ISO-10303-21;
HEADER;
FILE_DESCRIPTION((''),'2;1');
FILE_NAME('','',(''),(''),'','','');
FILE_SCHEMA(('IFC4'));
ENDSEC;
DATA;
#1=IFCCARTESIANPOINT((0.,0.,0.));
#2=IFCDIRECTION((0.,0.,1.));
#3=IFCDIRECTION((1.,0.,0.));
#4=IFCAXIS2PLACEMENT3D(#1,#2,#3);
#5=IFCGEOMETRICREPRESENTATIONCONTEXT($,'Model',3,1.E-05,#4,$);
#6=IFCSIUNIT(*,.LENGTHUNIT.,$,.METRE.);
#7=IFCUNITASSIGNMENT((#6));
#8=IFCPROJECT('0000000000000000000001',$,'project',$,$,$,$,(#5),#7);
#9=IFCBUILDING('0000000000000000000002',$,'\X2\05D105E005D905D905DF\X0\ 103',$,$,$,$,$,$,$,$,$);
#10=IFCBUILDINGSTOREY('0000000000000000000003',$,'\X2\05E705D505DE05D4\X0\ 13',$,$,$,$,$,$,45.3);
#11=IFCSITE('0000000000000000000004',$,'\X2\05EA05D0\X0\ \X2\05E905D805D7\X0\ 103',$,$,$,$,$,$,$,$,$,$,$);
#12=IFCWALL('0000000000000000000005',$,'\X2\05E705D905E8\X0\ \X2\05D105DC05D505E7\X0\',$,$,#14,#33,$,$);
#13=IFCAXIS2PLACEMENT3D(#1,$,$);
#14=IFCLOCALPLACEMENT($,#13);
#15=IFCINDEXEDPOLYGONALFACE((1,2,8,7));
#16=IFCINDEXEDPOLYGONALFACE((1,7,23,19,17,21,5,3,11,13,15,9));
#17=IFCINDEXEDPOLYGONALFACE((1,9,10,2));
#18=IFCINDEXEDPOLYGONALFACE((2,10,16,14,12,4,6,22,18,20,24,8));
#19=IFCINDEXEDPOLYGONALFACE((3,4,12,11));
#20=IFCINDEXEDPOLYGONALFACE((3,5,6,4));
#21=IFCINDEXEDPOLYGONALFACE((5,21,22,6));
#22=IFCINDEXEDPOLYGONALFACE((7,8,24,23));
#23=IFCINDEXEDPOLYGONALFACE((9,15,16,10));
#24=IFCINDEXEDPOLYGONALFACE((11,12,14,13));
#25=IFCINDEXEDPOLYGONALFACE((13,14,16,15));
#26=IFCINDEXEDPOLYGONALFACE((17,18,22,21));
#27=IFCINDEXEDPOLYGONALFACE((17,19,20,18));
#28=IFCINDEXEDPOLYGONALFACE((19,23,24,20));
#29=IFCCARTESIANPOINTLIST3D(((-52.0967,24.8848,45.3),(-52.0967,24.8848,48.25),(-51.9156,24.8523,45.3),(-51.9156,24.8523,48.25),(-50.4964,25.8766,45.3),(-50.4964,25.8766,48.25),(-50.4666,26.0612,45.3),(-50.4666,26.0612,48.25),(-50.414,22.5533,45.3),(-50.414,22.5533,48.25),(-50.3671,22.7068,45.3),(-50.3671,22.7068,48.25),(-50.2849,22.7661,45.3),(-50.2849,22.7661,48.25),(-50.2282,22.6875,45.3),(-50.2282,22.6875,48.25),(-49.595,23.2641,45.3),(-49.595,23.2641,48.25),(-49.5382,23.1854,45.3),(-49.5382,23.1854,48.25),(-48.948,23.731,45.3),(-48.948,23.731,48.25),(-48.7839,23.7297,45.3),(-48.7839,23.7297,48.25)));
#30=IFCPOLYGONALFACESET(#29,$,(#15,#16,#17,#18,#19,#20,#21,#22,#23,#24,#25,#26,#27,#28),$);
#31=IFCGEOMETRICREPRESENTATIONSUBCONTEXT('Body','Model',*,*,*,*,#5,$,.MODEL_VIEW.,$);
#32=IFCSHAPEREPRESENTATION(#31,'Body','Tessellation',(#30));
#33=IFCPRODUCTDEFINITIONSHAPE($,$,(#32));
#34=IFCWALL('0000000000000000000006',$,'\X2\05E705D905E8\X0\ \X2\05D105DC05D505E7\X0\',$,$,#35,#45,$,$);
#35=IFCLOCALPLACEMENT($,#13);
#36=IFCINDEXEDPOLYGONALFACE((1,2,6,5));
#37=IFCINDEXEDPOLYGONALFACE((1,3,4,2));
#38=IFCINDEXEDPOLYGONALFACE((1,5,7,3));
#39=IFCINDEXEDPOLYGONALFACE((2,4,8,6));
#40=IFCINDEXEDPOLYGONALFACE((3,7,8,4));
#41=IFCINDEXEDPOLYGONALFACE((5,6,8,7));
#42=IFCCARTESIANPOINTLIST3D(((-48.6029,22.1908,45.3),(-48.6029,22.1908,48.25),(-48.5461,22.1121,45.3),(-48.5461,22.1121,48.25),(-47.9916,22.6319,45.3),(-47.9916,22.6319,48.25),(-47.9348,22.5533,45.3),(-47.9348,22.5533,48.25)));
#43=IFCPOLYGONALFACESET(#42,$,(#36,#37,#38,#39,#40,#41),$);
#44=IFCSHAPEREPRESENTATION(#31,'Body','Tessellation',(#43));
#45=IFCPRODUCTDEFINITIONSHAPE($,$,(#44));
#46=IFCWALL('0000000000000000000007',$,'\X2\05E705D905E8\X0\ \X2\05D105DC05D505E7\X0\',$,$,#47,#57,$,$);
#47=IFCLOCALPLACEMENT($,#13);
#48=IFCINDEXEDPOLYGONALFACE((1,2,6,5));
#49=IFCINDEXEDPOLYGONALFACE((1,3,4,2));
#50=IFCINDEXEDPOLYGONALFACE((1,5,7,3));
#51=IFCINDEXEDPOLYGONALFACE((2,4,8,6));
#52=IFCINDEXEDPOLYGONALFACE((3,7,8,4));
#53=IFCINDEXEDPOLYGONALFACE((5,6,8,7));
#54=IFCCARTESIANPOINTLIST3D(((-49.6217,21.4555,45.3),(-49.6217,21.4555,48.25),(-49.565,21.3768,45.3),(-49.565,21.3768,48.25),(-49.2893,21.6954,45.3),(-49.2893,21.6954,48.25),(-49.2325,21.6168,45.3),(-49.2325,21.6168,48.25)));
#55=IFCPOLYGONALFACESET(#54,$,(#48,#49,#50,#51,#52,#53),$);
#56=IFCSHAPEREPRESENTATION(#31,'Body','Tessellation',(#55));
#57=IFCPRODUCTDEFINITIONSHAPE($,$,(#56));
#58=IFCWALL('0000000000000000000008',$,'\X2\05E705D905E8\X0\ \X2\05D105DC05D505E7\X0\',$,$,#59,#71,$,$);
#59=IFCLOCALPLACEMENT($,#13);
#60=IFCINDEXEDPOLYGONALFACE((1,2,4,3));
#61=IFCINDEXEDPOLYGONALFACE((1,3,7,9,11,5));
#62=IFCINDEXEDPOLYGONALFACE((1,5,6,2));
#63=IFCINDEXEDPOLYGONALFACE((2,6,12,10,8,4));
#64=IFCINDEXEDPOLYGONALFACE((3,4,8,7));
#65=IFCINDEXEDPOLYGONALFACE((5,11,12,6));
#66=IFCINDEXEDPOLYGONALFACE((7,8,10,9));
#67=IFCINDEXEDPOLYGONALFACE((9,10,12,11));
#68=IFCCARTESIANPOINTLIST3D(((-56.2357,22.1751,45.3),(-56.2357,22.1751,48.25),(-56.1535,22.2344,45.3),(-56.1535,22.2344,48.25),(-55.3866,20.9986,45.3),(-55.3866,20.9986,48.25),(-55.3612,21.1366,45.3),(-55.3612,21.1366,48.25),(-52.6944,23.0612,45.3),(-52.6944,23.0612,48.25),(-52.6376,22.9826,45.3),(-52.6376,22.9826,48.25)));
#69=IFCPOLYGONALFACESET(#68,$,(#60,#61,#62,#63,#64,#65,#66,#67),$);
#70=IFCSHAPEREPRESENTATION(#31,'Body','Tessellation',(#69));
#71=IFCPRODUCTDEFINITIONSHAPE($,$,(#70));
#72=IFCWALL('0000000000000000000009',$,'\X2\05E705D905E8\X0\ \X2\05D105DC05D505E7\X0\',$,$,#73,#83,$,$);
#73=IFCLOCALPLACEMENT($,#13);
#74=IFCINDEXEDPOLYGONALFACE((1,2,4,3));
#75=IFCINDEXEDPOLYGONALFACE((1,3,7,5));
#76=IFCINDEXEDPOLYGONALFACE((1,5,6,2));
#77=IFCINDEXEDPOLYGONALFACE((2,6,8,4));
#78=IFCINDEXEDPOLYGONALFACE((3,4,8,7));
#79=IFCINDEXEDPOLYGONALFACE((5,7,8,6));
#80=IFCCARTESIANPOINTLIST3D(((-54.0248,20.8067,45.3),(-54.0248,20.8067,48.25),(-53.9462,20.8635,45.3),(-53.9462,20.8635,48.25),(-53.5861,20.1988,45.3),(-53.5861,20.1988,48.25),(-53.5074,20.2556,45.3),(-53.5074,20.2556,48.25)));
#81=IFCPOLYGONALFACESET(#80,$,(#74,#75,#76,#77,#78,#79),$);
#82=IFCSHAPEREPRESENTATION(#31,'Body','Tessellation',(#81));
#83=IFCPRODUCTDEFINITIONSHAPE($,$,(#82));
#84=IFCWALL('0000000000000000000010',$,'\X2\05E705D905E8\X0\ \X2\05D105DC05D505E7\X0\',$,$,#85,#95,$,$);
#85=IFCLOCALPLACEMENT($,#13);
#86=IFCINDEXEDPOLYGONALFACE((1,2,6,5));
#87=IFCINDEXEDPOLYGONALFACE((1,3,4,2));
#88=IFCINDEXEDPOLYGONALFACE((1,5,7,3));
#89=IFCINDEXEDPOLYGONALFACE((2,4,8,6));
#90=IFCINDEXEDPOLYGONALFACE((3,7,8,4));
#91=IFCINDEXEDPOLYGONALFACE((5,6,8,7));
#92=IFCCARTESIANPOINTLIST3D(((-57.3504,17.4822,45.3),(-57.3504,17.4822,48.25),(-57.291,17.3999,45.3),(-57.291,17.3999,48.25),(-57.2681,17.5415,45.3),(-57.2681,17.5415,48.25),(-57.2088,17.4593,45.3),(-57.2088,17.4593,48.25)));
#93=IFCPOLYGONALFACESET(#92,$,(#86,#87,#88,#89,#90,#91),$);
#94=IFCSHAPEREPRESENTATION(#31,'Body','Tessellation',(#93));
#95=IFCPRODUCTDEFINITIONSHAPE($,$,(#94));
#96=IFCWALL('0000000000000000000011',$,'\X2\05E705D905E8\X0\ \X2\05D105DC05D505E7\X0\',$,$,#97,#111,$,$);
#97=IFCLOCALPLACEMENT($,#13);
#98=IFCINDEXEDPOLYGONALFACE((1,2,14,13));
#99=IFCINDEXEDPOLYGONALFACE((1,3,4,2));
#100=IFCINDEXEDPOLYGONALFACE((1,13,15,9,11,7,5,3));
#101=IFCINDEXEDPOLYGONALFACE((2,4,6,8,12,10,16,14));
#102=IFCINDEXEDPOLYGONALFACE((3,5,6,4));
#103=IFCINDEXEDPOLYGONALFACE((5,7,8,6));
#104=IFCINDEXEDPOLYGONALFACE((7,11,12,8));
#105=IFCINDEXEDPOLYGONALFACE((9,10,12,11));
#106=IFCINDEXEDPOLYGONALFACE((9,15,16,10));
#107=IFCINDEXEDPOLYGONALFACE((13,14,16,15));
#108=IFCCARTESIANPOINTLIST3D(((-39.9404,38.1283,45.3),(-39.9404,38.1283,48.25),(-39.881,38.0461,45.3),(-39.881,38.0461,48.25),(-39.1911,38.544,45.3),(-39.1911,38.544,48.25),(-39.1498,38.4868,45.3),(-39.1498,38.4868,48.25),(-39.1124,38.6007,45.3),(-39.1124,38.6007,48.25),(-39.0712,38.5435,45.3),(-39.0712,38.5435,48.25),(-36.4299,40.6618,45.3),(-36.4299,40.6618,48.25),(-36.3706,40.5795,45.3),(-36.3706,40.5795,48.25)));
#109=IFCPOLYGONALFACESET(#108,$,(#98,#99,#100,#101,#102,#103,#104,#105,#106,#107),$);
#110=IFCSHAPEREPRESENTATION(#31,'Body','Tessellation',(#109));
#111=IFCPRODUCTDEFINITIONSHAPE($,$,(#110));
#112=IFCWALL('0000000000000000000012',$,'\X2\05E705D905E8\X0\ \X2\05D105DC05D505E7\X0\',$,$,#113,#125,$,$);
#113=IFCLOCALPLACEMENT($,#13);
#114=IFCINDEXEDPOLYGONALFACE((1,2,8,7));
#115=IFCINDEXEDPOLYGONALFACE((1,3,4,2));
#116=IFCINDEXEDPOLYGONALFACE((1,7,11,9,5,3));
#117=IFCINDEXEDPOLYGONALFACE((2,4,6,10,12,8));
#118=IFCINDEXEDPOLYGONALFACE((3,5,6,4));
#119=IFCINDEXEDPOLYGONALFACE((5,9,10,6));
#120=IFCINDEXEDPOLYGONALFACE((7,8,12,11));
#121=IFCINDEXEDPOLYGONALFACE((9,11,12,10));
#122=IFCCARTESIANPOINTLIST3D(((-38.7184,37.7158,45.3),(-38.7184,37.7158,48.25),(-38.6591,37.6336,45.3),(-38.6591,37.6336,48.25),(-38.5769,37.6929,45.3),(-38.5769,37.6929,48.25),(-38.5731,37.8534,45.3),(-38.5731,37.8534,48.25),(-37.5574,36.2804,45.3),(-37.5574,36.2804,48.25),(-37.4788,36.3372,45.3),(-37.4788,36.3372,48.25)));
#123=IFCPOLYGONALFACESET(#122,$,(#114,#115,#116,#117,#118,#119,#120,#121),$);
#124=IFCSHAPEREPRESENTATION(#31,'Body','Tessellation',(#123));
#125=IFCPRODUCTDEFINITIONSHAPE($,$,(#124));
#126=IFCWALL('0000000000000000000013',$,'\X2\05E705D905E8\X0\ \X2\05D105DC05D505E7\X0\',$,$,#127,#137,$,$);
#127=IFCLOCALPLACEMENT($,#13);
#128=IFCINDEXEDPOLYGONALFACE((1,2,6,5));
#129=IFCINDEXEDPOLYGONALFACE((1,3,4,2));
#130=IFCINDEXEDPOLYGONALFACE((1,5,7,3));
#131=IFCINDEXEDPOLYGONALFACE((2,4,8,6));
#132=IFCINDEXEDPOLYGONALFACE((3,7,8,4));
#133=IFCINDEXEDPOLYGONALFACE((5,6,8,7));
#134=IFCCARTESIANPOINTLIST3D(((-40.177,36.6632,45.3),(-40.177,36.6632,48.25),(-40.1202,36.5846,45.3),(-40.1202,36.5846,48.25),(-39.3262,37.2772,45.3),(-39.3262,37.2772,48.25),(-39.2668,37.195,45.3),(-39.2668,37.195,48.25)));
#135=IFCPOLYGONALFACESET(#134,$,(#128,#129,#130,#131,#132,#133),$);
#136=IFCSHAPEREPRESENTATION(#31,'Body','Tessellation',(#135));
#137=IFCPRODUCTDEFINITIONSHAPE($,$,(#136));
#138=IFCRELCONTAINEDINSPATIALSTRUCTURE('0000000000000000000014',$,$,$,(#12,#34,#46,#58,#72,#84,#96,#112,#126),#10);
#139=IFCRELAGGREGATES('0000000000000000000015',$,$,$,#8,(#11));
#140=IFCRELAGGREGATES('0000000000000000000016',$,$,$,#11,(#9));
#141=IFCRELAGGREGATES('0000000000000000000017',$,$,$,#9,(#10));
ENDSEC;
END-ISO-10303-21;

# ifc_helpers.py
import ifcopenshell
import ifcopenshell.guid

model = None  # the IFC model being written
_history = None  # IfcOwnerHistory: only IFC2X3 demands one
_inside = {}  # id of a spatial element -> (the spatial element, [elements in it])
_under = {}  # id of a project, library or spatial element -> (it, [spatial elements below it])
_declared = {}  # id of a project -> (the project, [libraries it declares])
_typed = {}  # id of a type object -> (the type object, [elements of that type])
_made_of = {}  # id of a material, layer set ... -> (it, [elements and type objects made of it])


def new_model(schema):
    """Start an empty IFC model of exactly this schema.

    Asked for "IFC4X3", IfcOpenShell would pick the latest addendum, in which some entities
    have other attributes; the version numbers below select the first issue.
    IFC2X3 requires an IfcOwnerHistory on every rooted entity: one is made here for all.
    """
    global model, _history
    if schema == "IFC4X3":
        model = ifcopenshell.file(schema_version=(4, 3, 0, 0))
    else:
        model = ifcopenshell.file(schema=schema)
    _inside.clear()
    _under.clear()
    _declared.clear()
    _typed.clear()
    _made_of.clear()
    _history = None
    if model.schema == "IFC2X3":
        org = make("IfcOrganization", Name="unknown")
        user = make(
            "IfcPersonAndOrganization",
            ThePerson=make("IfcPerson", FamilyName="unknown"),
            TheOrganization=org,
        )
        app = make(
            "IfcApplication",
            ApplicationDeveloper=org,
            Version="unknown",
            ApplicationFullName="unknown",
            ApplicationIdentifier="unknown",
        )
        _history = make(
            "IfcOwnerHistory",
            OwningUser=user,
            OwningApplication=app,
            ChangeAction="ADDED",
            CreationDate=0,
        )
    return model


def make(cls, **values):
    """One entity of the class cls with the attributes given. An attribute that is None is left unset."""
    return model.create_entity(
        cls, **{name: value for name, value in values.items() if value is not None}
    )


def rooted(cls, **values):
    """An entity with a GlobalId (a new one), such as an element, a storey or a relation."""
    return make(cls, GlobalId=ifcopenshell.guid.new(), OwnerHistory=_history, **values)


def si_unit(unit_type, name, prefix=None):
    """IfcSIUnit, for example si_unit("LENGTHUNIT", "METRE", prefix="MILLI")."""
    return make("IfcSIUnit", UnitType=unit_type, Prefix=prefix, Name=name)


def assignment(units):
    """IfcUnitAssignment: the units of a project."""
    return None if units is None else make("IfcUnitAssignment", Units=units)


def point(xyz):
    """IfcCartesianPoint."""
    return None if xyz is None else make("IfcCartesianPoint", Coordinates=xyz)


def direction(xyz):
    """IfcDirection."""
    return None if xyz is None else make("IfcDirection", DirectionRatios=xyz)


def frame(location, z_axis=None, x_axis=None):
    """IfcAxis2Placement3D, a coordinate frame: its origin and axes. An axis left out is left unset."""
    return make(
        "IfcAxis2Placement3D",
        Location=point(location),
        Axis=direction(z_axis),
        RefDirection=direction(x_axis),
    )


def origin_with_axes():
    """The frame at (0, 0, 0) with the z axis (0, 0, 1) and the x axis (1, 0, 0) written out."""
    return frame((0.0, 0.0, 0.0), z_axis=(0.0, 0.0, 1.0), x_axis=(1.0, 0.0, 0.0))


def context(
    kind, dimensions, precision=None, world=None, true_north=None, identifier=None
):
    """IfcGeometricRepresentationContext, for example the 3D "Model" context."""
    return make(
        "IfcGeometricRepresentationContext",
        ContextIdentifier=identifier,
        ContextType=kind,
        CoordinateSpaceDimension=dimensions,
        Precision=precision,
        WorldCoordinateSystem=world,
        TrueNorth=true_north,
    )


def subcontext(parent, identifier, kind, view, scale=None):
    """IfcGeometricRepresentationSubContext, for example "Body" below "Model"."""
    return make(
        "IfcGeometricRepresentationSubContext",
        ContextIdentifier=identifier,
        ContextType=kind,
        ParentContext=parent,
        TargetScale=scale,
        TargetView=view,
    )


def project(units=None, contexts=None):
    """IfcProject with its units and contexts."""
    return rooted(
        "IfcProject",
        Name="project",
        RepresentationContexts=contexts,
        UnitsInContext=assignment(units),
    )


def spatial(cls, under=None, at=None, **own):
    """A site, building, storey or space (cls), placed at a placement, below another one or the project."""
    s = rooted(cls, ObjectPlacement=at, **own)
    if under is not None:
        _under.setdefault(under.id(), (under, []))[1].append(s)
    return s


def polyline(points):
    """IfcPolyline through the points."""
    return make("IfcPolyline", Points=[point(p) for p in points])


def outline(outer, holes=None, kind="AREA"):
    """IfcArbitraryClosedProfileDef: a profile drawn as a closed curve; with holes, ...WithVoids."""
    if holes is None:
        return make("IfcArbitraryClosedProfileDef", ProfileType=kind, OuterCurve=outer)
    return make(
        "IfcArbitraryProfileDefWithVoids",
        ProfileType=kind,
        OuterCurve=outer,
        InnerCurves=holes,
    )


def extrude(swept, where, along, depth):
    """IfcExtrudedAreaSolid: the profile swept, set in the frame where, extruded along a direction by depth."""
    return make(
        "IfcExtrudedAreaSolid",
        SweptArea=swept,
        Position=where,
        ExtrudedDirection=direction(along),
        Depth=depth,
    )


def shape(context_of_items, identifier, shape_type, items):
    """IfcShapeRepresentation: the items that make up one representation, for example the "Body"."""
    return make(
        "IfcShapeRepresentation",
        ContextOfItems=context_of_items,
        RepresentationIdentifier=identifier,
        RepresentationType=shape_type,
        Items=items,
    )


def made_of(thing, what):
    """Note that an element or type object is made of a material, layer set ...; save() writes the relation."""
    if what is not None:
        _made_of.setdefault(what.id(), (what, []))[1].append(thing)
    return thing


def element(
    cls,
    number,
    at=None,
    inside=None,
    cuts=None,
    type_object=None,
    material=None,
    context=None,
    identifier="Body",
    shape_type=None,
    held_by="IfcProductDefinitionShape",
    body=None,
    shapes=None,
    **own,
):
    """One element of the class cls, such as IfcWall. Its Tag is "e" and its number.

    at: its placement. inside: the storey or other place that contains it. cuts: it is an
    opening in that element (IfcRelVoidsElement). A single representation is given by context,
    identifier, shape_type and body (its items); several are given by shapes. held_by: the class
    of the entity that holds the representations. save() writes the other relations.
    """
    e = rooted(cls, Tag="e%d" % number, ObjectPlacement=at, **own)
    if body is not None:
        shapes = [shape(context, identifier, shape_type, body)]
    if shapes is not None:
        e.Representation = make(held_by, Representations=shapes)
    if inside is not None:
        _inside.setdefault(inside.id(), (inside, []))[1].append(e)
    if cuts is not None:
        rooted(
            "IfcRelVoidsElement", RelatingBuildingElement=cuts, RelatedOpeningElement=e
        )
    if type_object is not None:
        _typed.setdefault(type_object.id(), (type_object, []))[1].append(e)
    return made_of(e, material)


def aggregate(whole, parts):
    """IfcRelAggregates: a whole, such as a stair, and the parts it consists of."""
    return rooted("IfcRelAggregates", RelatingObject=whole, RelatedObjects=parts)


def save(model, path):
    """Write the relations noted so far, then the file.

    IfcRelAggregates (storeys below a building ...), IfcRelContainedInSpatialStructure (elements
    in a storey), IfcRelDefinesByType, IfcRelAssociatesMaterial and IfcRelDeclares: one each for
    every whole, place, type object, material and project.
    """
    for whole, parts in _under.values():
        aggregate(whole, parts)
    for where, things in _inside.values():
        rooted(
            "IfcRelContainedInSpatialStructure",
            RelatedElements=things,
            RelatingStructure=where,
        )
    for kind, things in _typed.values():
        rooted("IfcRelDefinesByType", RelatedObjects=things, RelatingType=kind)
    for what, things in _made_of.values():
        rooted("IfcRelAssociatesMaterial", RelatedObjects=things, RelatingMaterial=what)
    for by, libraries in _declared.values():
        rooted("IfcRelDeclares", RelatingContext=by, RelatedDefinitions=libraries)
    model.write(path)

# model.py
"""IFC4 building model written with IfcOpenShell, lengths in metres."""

from ifc_helpers import new_model, si_unit, frame, origin_with_axes, context, subcontext, project, spatial, polyline, outline, extrude, element, save


model = new_model("IFC4")

# Units and contexts
model_context = context("Model", 3, precision=1e-05, world=origin_with_axes())
body_context = subcontext(model_context, "Body", "Model", "MODEL_VIEW")
ifc_project = project(units=[si_unit("LENGTHUNIT", "METRE")], contexts=[model_context])

# Site, building, storey
site = spatial("IfcSite", under=ifc_project, Name="תא שטח 103")
building = spatial("IfcBuilding", under=site, Name="בניין 103")
storey = spatial("IfcBuildingStorey", under=building, Name="קומה 13", Elevation=45.3)

# Walls
element("IfcWall", 1, inside=storey, Name="קיר בלוק", context=body_context, shape_type="SweptSolid", body=[
    extrude(outline(polyline([(-48.948, 23.731), (-50.4964, 25.8766), (-51.9156, 24.8523), (-50.3671, 22.7068), (-50.2849, 22.7661), (-50.2282, 22.6875), (-50.414, 22.5533), (-52.0967, 24.8848), (-50.4666, 26.0612), (-48.7839, 23.7297), (-49.5382, 23.1854), (-49.595, 23.2641), (-48.948, 23.731)])), frame((0.0, 0.0, 45.3)), (0.0, 0.0, 1.0), 2.95),
])
element("IfcWall", 2, inside=storey, Name="קיר בלוק", context=body_context, shape_type="SweptSolid", body=[
    extrude(outline(polyline([(-47.9348, 22.5533), (-48.5461, 22.1121), (-48.6029, 22.1908), (-47.9916, 22.6319), (-47.9348, 22.5533)])), frame((0.0, 0.0, 45.3)), (0.0, 0.0, 1.0), 2.95),
])
element("IfcWall", 3, inside=storey, Name="קיר בלוק", context=body_context, shape_type="SweptSolid", body=[
    extrude(outline(polyline([(-49.565, 21.3768), (-49.6217, 21.4555), (-49.2893, 21.6954), (-49.2325, 21.6168), (-49.565, 21.3768)])), frame((0.0, 0.0, 45.3)), (0.0, 0.0, 1.0), 2.95),
])
element("IfcWall", 4, inside=storey, Name="קיר בלוק", context=body_context, shape_type="SweptSolid", body=[
    extrude(outline(polyline([(-56.1535, 22.2344), (-55.3612, 21.1366), (-52.6944, 23.0612), (-52.6376, 22.9826), (-55.3866, 20.9986), (-56.2357, 22.1751), (-56.1535, 22.2344)])), frame((0.0, 0.0, 45.3)), (0.0, 0.0, 1.0), 2.95),
])
element("IfcWall", 5, inside=storey, Name="קיר בלוק", context=body_context, shape_type="SweptSolid", body=[
    extrude(outline(polyline([(-53.5861, 20.1988), (-54.0248, 20.8067), (-53.9462, 20.8635), (-53.5074, 20.2556), (-53.5861, 20.1988)])), frame((0.0, 0.0, 45.3)), (0.0, 0.0, 1.0), 2.95),
])
element("IfcWall", 6, inside=storey, Name="קיר בלוק", context=body_context, shape_type="SweptSolid", body=[
    extrude(outline(polyline([(-57.291, 17.3999), (-57.3504, 17.4822), (-57.2681, 17.5415), (-57.2088, 17.4593), (-57.291, 17.3999)])), frame((0.0, 0.0, 45.3)), (0.0, 0.0, 1.0), 2.95),
])
element("IfcWall", 7, inside=storey, Name="קיר בלוק", context=body_context, shape_type="SweptSolid", body=[
    extrude(outline(polyline([(-39.881, 38.0461), (-39.9404, 38.1283), (-36.4299, 40.6618), (-36.3706, 40.5795), (-39.1124, 38.6007), (-39.0712, 38.5435), (-39.1498, 38.4868), (-39.1911, 38.544), (-39.881, 38.0461)])), frame((0.0, 0.0, 45.3)), (0.0, 0.0, 1.0), 2.95),
])
element("IfcWall", 8, inside=storey, Name="קיר בלוק", context=body_context, shape_type="SweptSolid", body=[
    extrude(outline(polyline([(-38.6591, 37.6336), (-38.7184, 37.7158), (-38.5731, 37.8534), (-37.4788, 36.3372), (-37.5574, 36.2804), (-38.5769, 37.6929), (-38.6591, 37.6336)])), frame((0.0, 0.0, 45.3)), (0.0, 0.0, 1.0), 2.95),
])
element("IfcWall", 9, inside=storey, Name="קיר בלוק", context=body_context, shape_type="SweptSolid", body=[
    extrude(outline(polyline([(-40.177, 36.6632), (-39.3262, 37.2772), (-39.2668, 37.195), (-40.1202, 36.5846), (-40.177, 36.6632)])), frame((0.0, 0.0, 45.3)), (0.0, 0.0, 1.0), 2.95),
])

save(model, "model.ifc")
